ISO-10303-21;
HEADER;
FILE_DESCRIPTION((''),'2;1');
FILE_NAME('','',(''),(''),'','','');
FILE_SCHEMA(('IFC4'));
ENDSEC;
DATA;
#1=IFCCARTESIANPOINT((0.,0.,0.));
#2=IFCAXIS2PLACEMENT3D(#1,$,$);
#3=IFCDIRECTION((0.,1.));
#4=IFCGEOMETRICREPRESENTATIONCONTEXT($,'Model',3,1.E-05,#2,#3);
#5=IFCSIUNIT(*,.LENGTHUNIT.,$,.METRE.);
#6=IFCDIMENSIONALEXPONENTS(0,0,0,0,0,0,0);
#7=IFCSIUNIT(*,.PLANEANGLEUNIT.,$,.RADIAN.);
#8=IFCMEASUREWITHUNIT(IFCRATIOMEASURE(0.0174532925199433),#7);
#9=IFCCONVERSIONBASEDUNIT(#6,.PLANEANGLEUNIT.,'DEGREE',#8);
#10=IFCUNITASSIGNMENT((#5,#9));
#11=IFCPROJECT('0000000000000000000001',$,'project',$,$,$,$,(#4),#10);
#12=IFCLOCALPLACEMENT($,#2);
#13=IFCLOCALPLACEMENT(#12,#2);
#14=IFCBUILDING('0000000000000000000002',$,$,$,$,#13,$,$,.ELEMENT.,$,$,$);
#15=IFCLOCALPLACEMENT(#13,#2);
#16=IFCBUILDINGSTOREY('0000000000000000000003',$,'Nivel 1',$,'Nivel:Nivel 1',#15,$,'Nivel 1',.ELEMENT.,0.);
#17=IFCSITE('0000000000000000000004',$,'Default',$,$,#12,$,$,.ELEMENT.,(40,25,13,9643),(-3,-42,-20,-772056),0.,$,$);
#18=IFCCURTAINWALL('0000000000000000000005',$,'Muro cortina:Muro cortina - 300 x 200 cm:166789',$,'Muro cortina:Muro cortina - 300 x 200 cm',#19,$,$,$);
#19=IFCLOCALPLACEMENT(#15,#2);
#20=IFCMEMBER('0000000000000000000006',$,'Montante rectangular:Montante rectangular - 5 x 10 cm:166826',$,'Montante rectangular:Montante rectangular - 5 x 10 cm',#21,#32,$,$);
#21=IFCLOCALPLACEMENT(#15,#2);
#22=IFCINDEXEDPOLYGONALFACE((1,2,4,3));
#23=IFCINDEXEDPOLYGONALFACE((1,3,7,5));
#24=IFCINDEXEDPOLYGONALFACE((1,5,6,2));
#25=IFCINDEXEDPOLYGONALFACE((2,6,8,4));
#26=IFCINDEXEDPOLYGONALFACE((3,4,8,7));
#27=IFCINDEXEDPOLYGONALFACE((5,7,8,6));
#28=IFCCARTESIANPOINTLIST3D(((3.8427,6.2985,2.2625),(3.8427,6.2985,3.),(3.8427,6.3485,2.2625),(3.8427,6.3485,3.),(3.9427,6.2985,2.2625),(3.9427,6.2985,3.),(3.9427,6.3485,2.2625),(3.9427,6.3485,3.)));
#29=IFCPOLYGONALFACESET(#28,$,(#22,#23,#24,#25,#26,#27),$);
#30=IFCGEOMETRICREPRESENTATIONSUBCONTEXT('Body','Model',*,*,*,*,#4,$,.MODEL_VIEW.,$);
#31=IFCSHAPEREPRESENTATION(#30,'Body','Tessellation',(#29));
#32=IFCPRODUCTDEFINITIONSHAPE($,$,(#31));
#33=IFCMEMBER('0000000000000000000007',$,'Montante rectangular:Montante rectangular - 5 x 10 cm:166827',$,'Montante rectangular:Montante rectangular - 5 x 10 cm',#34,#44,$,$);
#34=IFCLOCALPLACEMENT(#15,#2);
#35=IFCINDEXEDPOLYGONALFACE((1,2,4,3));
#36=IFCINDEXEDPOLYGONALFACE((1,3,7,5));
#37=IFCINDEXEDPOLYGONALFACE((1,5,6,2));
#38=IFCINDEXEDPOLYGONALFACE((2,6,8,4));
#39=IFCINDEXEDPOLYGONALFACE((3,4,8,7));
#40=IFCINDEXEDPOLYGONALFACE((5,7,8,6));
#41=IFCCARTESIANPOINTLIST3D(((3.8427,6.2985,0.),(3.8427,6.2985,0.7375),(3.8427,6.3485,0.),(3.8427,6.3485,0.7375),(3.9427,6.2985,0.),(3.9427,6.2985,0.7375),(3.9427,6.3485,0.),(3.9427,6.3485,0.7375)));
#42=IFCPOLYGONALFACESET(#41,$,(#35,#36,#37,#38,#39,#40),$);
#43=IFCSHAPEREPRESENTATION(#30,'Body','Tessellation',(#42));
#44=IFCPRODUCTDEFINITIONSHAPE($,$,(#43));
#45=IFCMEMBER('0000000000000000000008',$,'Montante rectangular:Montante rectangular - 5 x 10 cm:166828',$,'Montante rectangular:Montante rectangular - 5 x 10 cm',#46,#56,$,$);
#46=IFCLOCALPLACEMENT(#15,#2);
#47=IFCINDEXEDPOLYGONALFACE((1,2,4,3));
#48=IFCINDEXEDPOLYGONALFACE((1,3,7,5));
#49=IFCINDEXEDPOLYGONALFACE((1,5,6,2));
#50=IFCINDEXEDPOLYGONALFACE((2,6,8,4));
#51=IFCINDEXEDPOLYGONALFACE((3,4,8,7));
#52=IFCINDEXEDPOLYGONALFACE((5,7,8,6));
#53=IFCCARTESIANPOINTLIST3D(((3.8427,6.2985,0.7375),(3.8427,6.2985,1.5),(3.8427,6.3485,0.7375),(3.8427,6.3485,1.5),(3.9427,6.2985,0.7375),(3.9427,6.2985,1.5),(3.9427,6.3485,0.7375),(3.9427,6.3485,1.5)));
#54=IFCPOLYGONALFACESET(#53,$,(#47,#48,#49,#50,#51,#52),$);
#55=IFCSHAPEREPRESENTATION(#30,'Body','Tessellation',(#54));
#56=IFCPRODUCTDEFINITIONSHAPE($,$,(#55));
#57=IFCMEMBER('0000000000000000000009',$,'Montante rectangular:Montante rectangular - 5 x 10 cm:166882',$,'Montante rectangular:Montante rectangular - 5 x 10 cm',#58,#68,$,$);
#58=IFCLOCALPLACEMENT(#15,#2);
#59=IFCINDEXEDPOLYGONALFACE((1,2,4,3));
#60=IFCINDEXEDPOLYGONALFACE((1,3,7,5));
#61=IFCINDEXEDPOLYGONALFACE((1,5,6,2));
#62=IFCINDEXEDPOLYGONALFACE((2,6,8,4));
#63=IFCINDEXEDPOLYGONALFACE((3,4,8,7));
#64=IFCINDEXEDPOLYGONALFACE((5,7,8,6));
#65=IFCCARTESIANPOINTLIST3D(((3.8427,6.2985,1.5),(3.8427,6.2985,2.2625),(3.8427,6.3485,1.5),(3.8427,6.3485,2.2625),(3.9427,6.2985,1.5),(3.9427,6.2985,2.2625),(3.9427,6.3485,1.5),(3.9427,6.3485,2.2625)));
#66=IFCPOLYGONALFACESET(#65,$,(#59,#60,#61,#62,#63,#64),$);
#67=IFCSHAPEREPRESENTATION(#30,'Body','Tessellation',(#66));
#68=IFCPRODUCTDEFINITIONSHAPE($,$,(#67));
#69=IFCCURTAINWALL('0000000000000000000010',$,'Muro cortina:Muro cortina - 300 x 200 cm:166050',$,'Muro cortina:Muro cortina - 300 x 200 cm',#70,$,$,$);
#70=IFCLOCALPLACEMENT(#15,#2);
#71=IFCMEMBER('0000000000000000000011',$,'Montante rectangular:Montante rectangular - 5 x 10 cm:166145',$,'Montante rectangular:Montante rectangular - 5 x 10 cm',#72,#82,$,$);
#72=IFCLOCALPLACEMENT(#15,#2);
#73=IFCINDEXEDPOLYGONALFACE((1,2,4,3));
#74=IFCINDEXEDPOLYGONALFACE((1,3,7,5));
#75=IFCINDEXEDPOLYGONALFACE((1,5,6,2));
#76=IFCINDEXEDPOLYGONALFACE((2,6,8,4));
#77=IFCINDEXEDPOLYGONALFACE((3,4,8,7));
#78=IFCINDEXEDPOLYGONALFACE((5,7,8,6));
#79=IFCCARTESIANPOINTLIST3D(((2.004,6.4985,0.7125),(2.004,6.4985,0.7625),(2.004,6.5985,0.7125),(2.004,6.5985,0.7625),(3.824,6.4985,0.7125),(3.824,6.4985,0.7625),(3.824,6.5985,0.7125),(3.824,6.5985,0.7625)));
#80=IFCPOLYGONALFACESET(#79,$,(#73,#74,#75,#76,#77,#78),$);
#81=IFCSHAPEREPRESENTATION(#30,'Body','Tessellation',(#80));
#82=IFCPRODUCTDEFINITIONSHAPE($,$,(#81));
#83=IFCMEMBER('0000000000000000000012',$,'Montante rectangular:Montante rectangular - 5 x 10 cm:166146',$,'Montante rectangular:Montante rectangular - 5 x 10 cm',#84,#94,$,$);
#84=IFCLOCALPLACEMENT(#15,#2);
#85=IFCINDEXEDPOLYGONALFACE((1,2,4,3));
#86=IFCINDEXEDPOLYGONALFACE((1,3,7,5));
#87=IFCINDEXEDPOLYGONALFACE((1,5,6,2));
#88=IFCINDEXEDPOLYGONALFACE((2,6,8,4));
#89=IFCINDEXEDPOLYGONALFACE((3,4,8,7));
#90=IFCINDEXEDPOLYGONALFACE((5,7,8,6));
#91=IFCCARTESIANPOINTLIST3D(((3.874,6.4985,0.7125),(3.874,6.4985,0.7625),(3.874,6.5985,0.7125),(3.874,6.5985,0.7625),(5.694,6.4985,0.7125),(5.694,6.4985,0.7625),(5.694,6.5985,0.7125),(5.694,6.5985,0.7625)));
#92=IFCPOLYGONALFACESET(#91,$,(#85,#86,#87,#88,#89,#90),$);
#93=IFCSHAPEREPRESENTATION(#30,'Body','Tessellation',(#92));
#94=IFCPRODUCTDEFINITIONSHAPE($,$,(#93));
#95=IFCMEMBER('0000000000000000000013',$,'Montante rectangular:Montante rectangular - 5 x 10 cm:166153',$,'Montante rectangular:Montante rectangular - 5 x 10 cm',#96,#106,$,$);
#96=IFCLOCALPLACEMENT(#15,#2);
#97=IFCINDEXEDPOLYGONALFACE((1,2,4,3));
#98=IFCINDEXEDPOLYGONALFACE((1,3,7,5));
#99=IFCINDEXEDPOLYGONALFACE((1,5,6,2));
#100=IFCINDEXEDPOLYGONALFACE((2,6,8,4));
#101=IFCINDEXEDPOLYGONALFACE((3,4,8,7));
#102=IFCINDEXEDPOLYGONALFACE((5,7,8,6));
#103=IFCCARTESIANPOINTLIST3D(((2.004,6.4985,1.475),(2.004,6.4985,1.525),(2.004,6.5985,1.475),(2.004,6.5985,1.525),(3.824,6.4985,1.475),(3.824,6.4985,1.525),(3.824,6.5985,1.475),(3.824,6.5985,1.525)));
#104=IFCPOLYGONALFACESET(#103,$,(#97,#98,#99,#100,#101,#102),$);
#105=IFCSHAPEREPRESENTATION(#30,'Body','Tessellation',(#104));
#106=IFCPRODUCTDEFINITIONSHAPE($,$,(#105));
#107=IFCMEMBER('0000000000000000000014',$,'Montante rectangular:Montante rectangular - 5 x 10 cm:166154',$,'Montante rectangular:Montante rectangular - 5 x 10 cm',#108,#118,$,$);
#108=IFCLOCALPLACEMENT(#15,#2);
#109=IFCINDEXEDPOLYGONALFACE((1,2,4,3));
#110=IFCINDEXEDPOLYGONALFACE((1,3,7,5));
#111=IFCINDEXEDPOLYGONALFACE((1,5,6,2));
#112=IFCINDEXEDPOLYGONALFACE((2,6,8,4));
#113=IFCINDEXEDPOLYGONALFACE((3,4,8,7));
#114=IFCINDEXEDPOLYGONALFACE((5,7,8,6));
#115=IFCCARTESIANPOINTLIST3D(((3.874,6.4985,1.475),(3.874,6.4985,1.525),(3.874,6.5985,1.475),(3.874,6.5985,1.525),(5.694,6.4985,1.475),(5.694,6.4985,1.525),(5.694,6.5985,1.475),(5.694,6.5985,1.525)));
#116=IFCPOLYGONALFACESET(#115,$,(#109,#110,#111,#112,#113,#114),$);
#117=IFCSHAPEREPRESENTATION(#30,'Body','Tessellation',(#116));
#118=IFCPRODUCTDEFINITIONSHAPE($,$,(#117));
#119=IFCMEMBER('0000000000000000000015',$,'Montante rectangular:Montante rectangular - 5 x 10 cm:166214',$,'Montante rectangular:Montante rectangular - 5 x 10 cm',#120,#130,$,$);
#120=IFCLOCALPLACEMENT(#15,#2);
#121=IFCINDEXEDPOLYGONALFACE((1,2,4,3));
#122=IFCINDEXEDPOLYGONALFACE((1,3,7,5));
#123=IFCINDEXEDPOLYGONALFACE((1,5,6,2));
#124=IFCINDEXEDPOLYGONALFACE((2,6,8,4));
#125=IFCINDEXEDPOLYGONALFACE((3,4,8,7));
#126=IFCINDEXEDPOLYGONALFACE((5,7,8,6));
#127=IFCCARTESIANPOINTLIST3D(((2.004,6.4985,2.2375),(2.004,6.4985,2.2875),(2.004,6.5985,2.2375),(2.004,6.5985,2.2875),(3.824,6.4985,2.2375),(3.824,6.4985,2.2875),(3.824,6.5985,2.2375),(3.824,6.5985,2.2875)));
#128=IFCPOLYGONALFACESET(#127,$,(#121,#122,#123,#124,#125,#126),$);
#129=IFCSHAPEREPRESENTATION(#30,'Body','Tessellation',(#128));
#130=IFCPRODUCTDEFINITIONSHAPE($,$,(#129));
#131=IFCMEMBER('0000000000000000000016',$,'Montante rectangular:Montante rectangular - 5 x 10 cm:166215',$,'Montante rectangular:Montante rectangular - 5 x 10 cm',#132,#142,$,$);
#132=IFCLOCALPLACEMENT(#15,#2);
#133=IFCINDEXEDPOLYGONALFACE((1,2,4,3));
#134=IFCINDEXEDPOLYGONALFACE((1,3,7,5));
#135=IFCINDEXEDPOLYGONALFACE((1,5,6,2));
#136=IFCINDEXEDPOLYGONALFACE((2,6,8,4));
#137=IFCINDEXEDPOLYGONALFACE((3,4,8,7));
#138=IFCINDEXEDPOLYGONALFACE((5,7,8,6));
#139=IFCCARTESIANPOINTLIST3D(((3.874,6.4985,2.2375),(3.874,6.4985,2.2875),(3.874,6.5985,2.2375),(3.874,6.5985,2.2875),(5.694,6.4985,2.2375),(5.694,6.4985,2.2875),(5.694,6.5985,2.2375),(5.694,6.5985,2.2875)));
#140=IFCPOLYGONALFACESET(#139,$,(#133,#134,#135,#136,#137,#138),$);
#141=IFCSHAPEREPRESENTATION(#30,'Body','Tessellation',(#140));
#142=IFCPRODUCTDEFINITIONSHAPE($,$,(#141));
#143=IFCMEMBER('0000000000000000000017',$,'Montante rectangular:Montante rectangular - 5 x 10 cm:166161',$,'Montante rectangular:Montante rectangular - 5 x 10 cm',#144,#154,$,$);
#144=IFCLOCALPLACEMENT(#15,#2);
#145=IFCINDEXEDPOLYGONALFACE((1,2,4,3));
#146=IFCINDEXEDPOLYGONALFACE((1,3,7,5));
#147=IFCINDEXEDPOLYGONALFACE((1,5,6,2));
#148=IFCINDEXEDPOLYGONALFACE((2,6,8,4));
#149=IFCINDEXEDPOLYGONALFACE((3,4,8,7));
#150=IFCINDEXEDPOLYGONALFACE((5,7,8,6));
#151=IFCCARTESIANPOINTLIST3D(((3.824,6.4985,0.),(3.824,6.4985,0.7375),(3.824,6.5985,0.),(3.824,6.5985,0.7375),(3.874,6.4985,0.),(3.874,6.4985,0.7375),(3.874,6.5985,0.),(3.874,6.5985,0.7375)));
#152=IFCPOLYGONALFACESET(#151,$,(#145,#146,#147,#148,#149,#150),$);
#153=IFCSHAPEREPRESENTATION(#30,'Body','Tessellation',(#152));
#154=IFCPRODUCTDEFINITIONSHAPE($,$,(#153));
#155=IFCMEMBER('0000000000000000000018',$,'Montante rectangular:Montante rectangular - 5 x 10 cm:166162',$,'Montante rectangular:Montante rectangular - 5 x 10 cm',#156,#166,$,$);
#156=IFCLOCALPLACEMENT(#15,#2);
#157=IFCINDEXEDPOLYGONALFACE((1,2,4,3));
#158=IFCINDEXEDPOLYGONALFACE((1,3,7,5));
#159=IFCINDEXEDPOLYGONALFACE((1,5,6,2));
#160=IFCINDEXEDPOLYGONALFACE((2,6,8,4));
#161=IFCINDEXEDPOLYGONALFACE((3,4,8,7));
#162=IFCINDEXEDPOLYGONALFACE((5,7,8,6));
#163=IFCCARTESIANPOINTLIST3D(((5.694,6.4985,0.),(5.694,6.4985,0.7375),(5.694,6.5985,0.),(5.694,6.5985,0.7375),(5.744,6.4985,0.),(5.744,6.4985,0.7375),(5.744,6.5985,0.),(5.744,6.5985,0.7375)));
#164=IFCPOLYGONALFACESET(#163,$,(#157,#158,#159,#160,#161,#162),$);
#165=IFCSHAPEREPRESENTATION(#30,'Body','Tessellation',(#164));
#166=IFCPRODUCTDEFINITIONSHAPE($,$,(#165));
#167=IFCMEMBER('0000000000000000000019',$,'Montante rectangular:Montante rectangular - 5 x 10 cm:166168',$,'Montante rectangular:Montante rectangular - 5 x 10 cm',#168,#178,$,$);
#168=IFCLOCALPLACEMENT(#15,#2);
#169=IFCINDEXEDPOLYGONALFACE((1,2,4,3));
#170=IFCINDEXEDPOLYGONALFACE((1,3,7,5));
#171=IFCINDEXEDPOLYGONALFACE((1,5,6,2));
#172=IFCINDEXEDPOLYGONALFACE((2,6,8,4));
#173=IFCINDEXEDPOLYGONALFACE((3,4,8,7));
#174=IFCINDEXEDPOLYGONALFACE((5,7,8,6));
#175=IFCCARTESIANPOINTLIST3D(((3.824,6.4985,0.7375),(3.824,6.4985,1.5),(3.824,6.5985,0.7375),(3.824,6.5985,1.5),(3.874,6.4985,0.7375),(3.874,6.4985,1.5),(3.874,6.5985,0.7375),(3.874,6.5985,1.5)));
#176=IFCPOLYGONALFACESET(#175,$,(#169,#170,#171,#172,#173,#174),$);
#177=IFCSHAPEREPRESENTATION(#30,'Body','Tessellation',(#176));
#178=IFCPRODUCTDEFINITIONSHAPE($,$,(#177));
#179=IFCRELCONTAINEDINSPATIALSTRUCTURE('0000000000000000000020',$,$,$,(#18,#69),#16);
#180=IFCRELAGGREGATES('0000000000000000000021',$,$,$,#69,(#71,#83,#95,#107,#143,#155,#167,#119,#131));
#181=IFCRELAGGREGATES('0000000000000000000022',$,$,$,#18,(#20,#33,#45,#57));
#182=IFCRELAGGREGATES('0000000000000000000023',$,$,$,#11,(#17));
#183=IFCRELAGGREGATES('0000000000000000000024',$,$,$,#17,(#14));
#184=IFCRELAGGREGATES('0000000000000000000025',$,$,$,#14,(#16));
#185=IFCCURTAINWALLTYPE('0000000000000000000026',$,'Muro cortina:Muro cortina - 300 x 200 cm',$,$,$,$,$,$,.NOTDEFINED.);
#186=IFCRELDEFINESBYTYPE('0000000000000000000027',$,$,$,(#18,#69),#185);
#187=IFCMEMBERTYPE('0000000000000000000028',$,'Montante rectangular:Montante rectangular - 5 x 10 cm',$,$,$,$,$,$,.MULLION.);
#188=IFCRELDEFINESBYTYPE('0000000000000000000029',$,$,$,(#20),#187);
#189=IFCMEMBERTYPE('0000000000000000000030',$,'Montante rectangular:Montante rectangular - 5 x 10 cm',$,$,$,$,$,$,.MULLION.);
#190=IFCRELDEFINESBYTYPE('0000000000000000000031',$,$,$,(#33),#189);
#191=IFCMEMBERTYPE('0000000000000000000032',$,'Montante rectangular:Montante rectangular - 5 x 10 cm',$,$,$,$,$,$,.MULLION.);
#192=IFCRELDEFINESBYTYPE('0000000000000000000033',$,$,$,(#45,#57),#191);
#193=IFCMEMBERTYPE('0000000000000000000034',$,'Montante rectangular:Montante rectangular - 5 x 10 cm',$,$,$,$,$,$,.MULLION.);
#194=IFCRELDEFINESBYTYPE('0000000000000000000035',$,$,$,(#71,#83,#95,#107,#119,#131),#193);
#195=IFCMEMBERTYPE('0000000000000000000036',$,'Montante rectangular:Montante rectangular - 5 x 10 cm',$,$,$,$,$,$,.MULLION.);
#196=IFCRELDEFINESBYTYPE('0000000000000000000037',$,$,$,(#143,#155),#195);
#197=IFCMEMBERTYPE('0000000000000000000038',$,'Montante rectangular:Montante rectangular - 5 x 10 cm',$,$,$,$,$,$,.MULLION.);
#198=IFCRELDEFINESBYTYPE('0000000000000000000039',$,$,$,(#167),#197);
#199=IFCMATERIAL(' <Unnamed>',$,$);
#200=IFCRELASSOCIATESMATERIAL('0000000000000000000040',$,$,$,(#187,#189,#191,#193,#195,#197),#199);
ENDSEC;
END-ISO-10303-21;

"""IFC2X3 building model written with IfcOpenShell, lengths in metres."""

from ifc_helpers import new_model, entity, si_unit, converted_unit, direction, frame, origin, origin_2d_with_axis, place, context, subcontext, project, spatial, rectangle, extrude, source, transform, mapped, material, type_object, type_shapes, element, aggregate, save


model = new_model("IFC2X3")

# Units and contexts
model_context = context("Model", 3, precision=1e-05, world=origin(), true_north=direction((0.0, 1.0)))
body_context = subcontext(model_context, "Body", "Model", "MODEL_VIEW")
ifc_project = project(units=[si_unit("LENGTHUNIT", "METRE"), converted_unit("PLANEANGLEUNIT", "DEGREE", entity("IfcRatioMeasure", 0.0174532925199433), si_unit("PLANEANGLEUNIT", "RADIAN"), dimensions=[0, 0, 0, 0, 0, 0, 0])], contexts=[model_context])

# Site, building, storey
site_placement = place(None, origin())
site = spatial("IfcSite", under=ifc_project, at=site_placement, Name="Default", CompositionType="ELEMENT", RefLatitude=(40, 25, 13, 9643), RefLongitude=(-3, -42, -20, -772056), RefElevation=0.0)
building_placement = place(site_placement, origin())
building = spatial("IfcBuilding", under=site, at=building_placement, CompositionType="ELEMENT")
storey_placement = place(building_placement, origin())
storey = spatial("IfcBuildingStorey", under=building, at=storey_placement, Name="Nivel 1", ObjectType="Nivel:Nivel 1", LongName="Nivel 1", CompositionType="ELEMENT", Elevation=0.0)

# Curtain walls, members
curtain_wall_type = type_object("IfcCurtainWallType", Name="Muro cortina:Muro cortina - 300 x 200 cm", PredefinedType="NOTDEFINED")
curtain_wall_1_placement = place(storey_placement, origin())
curtain_wall_1 = element("IfcCurtainWall", 1, at=curtain_wall_1_placement, inside=storey, type_object=curtain_wall_type, Name="Muro cortina:Muro cortina - 300 x 200 cm:166789", ObjectType="Muro cortina:Muro cortina - 300 x 200 cm")
ifc_material_1 = material(Name=" <Unnamed>")
member_type_1 = type_object("IfcMemberType", Name="Montante rectangular:Montante rectangular - 5 x 10 cm", PredefinedType="MULLION", material=ifc_material_1)
shared_shape_1 = source(origin(), body_context, "Body", "SweptSolid", [
    extrude(rectangle(XDim=0.1, YDim=0.05, at=origin_2d_with_axis()), frame((-0.025, 0.0, -0.7375), z_axis=(0.0, 0.0, 1.0), x_axis=(0.0, -1.0, 0.0)), (0.0, 0.0, 1.0), 0.7375),
])
type_shapes(member_type_1, [shared_shape_1])
member_1_placement = place(storey_placement, frame((3.8927, 6.3485, 3.0), z_axis=(0.0, 0.0, 1.0), x_axis=(0.0, 1.0, 0.0)))
member_1 = element("IfcMember", 2, at=member_1_placement, type_object=member_type_1, Name="Montante rectangular:Montante rectangular - 5 x 10 cm:166826", ObjectType="Montante rectangular:Montante rectangular - 5 x 10 cm", context=body_context, shape_type="MappedRepresentation", body=[
    mapped(shared_shape_1, transform((0.0, 0.0, 0.0), scale=1.0)),
])
member_type_2 = type_object("IfcMemberType", Name="Montante rectangular:Montante rectangular - 5 x 10 cm", PredefinedType="MULLION", material=ifc_material_1)
shared_shape_2 = source(origin(), body_context, "Body", "SweptSolid", [
    extrude(rectangle(XDim=0.1, YDim=0.05, at=origin_2d_with_axis()), frame((-0.025, 0.0, -0.7375), z_axis=(0.0, 0.0, 1.0), x_axis=(0.0, -1.0, 0.0)), (0.0, 0.0, 1.0), 0.7375),
])
type_shapes(member_type_2, [shared_shape_2])
member_2_placement = place(storey_placement, frame((3.8927, 6.3485, 0.7375), z_axis=(0.0, 0.0, 1.0), x_axis=(0.0, 1.0, 0.0)))
member_2 = element("IfcMember", 3, at=member_2_placement, type_object=member_type_2, Name="Montante rectangular:Montante rectangular - 5 x 10 cm:166827", ObjectType="Montante rectangular:Montante rectangular - 5 x 10 cm", context=body_context, shape_type="MappedRepresentation", body=[
    mapped(shared_shape_2, transform((0.0, 0.0, 0.0), scale=1.0)),
])
member_type_3 = type_object("IfcMemberType", Name="Montante rectangular:Montante rectangular - 5 x 10 cm", PredefinedType="MULLION", material=ifc_material_1)
shared_shape_3 = source(origin(), body_context, "Body", "SweptSolid", [
    extrude(rectangle(XDim=0.1, YDim=0.05, at=origin_2d_with_axis()), frame((-0.025, 0.0, -0.7625), z_axis=(0.0, 0.0, 1.0), x_axis=(0.0, -1.0, 0.0)), (0.0, 0.0, 1.0), 0.7625),
])
type_shapes(member_type_3, [shared_shape_3])
member_3_placement = place(storey_placement, frame((3.8927, 6.3485, 1.5), z_axis=(0.0, 0.0, 1.0), x_axis=(0.0, 1.0, 0.0)))
member_3 = element("IfcMember", 4, at=member_3_placement, type_object=member_type_3, Name="Montante rectangular:Montante rectangular - 5 x 10 cm:166828", ObjectType="Montante rectangular:Montante rectangular - 5 x 10 cm", context=body_context, shape_type="MappedRepresentation", body=[
    mapped(shared_shape_3, transform((0.0, 0.0, 0.0), scale=1.0)),
])
member_4_placement = place(storey_placement, frame((3.8927, 6.3485, 2.2625), z_axis=(0.0, 0.0, 1.0), x_axis=(0.0, 1.0, 0.0)))
member_4 = element("IfcMember", 5, at=member_4_placement, type_object=member_type_3, Name="Montante rectangular:Montante rectangular - 5 x 10 cm:166882", ObjectType="Montante rectangular:Montante rectangular - 5 x 10 cm", context=body_context, shape_type="MappedRepresentation", body=[
    mapped(shared_shape_3, transform((0.0, 0.0, 0.0), scale=1.0)),
])
curtain_wall_2_placement = place(storey_placement, origin())
curtain_wall_2 = element("IfcCurtainWall", 6, at=curtain_wall_2_placement, inside=storey, type_object=curtain_wall_type, Name="Muro cortina:Muro cortina - 300 x 200 cm:166050", ObjectType="Muro cortina:Muro cortina - 300 x 200 cm")
member_type_4 = type_object("IfcMemberType", Name="Montante rectangular:Montante rectangular - 5 x 10 cm", PredefinedType="MULLION", material=ifc_material_1)
shared_shape_4 = source(origin(), body_context, "Body", "SweptSolid", [
    extrude(rectangle(XDim=0.1, YDim=0.05, at=origin_2d_with_axis()), frame((0.0, 0.0, -1.82), z_axis=(0.0, 0.0, 1.0), x_axis=(0.0, -1.0, 0.0)), (0.0, 0.0, 1.0), 1.82),
])
type_shapes(member_type_4, [shared_shape_4])
member_5_placement = place(storey_placement, frame((3.824, 6.5485, 0.7375), z_axis=(1.0, 0.0, 0.0), x_axis=(0.0, 0.0, 1.0)))
member_5 = element("IfcMember", 7, at=member_5_placement, type_object=member_type_4, Name="Montante rectangular:Montante rectangular - 5 x 10 cm:166145", ObjectType="Montante rectangular:Montante rectangular - 5 x 10 cm", context=body_context, shape_type="MappedRepresentation", body=[
    mapped(shared_shape_4, transform((0.0, 0.0, 0.0), scale=1.0)),
])
member_6_placement = place(storey_placement, frame((5.694, 6.5485, 0.7375), z_axis=(1.0, 0.0, 0.0), x_axis=(0.0, 0.0, 1.0)))
member_6 = element("IfcMember", 8, at=member_6_placement, type_object=member_type_4, Name="Montante rectangular:Montante rectangular - 5 x 10 cm:166146", ObjectType="Montante rectangular:Montante rectangular - 5 x 10 cm", context=body_context, shape_type="MappedRepresentation", body=[
    mapped(shared_shape_4, transform((0.0, 0.0, 0.0), scale=1.0)),
])
member_7_placement = place(storey_placement, frame((3.824, 6.5485, 1.5), z_axis=(1.0, 0.0, 0.0), x_axis=(0.0, 0.0, 1.0)))
member_7 = element("IfcMember", 9, at=member_7_placement, type_object=member_type_4, Name="Montante rectangular:Montante rectangular - 5 x 10 cm:166153", ObjectType="Montante rectangular:Montante rectangular - 5 x 10 cm", context=body_context, shape_type="MappedRepresentation", body=[
    mapped(shared_shape_4, transform((0.0, 0.0, 0.0), scale=1.0)),
])
member_8_placement = place(storey_placement, frame((5.694, 6.5485, 1.5), z_axis=(1.0, 0.0, 0.0), x_axis=(0.0, 0.0, 1.0)))
member_8 = element("IfcMember", 10, at=member_8_placement, type_object=member_type_4, Name="Montante rectangular:Montante rectangular - 5 x 10 cm:166154", ObjectType="Montante rectangular:Montante rectangular - 5 x 10 cm", context=body_context, shape_type="MappedRepresentation", body=[
    mapped(shared_shape_4, transform((0.0, 0.0, 0.0), scale=1.0)),
])
member_9_placement = place(storey_placement, frame((3.824, 6.5485, 2.2625), z_axis=(1.0, 0.0, 0.0), x_axis=(0.0, 0.0, 1.0)))
member_9 = element("IfcMember", 11, at=member_9_placement, type_object=member_type_4, Name="Montante rectangular:Montante rectangular - 5 x 10 cm:166214", ObjectType="Montante rectangular:Montante rectangular - 5 x 10 cm", context=body_context, shape_type="MappedRepresentation", body=[
    mapped(shared_shape_4, transform((0.0, 0.0, 0.0), scale=1.0)),
])
member_10_placement = place(storey_placement, frame((5.694, 6.5485, 2.2625), z_axis=(1.0, 0.0, 0.0), x_axis=(0.0, 0.0, 1.0)))
member_10 = element("IfcMember", 12, at=member_10_placement, type_object=member_type_4, Name="Montante rectangular:Montante rectangular - 5 x 10 cm:166215", ObjectType="Montante rectangular:Montante rectangular - 5 x 10 cm", context=body_context, shape_type="MappedRepresentation", body=[
    mapped(shared_shape_4, transform((0.0, 0.0, 0.0), scale=1.0)),
])
member_type_5 = type_object("IfcMemberType", Name="Montante rectangular:Montante rectangular - 5 x 10 cm", PredefinedType="MULLION", material=ifc_material_1)
shared_shape_5 = source(origin(), body_context, "Body", "SweptSolid", [
    extrude(rectangle(XDim=0.1, YDim=0.05, at=origin_2d_with_axis()), frame((0.0, 0.0, -0.7375), z_axis=(0.0, 0.0, 1.0), x_axis=(0.0, -1.0, 0.0)), (0.0, 0.0, 1.0), 0.7375),
])
type_shapes(member_type_5, [shared_shape_5])
member_11_placement = place(storey_placement, frame((3.849, 6.5485, 0.0), z_axis=(0.0, 0.0, -1.0), x_axis=(1.0, 0.0, 0.0)))
member_11 = element("IfcMember", 13, at=member_11_placement, type_object=member_type_5, Name="Montante rectangular:Montante rectangular - 5 x 10 cm:166161", ObjectType="Montante rectangular:Montante rectangular - 5 x 10 cm", context=body_context, shape_type="MappedRepresentation", body=[
    mapped(shared_shape_5, transform((0.0, 0.0, 0.0), scale=1.0)),
])
member_12_placement = place(storey_placement, frame((5.719, 6.5485, 0.0), z_axis=(0.0, 0.0, -1.0), x_axis=(1.0, 0.0, 0.0)))
member_12 = element("IfcMember", 14, at=member_12_placement, type_object=member_type_5, Name="Montante rectangular:Montante rectangular - 5 x 10 cm:166162", ObjectType="Montante rectangular:Montante rectangular - 5 x 10 cm", context=body_context, shape_type="MappedRepresentation", body=[
    mapped(shared_shape_5, transform((0.0, 0.0, 0.0), scale=1.0)),
])
member_type_6 = type_object("IfcMemberType", Name="Montante rectangular:Montante rectangular - 5 x 10 cm", PredefinedType="MULLION", material=ifc_material_1)
shared_shape_6 = source(origin(), body_context, "Body", "SweptSolid", [
    extrude(rectangle(XDim=0.1, YDim=0.05, at=origin_2d_with_axis()), frame((0.0, 0.0, -0.7625), z_axis=(0.0, 0.0, 1.0), x_axis=(0.0, -1.0, 0.0)), (0.0, 0.0, 1.0), 0.7625),
])
type_shapes(member_type_6, [shared_shape_6])
member_13_placement = place(storey_placement, frame((3.849, 6.5485, 0.7375), z_axis=(0.0, 0.0, -1.0), x_axis=(1.0, 0.0, 0.0)))
member_13 = element("IfcMember", 15, at=member_13_placement, type_object=member_type_6, Name="Montante rectangular:Montante rectangular - 5 x 10 cm:166168", ObjectType="Montante rectangular:Montante rectangular - 5 x 10 cm", context=body_context, shape_type="MappedRepresentation", body=[
    mapped(shared_shape_6, transform((0.0, 0.0, 0.0), scale=1.0)),
])

aggregate(curtain_wall_2, [member_5, member_6, member_7, member_8, member_11, member_12, member_13, member_9, member_10])
aggregate(curtain_wall_1, [member_1, member_2, member_3, member_4])

save(model, "model.ifc")
